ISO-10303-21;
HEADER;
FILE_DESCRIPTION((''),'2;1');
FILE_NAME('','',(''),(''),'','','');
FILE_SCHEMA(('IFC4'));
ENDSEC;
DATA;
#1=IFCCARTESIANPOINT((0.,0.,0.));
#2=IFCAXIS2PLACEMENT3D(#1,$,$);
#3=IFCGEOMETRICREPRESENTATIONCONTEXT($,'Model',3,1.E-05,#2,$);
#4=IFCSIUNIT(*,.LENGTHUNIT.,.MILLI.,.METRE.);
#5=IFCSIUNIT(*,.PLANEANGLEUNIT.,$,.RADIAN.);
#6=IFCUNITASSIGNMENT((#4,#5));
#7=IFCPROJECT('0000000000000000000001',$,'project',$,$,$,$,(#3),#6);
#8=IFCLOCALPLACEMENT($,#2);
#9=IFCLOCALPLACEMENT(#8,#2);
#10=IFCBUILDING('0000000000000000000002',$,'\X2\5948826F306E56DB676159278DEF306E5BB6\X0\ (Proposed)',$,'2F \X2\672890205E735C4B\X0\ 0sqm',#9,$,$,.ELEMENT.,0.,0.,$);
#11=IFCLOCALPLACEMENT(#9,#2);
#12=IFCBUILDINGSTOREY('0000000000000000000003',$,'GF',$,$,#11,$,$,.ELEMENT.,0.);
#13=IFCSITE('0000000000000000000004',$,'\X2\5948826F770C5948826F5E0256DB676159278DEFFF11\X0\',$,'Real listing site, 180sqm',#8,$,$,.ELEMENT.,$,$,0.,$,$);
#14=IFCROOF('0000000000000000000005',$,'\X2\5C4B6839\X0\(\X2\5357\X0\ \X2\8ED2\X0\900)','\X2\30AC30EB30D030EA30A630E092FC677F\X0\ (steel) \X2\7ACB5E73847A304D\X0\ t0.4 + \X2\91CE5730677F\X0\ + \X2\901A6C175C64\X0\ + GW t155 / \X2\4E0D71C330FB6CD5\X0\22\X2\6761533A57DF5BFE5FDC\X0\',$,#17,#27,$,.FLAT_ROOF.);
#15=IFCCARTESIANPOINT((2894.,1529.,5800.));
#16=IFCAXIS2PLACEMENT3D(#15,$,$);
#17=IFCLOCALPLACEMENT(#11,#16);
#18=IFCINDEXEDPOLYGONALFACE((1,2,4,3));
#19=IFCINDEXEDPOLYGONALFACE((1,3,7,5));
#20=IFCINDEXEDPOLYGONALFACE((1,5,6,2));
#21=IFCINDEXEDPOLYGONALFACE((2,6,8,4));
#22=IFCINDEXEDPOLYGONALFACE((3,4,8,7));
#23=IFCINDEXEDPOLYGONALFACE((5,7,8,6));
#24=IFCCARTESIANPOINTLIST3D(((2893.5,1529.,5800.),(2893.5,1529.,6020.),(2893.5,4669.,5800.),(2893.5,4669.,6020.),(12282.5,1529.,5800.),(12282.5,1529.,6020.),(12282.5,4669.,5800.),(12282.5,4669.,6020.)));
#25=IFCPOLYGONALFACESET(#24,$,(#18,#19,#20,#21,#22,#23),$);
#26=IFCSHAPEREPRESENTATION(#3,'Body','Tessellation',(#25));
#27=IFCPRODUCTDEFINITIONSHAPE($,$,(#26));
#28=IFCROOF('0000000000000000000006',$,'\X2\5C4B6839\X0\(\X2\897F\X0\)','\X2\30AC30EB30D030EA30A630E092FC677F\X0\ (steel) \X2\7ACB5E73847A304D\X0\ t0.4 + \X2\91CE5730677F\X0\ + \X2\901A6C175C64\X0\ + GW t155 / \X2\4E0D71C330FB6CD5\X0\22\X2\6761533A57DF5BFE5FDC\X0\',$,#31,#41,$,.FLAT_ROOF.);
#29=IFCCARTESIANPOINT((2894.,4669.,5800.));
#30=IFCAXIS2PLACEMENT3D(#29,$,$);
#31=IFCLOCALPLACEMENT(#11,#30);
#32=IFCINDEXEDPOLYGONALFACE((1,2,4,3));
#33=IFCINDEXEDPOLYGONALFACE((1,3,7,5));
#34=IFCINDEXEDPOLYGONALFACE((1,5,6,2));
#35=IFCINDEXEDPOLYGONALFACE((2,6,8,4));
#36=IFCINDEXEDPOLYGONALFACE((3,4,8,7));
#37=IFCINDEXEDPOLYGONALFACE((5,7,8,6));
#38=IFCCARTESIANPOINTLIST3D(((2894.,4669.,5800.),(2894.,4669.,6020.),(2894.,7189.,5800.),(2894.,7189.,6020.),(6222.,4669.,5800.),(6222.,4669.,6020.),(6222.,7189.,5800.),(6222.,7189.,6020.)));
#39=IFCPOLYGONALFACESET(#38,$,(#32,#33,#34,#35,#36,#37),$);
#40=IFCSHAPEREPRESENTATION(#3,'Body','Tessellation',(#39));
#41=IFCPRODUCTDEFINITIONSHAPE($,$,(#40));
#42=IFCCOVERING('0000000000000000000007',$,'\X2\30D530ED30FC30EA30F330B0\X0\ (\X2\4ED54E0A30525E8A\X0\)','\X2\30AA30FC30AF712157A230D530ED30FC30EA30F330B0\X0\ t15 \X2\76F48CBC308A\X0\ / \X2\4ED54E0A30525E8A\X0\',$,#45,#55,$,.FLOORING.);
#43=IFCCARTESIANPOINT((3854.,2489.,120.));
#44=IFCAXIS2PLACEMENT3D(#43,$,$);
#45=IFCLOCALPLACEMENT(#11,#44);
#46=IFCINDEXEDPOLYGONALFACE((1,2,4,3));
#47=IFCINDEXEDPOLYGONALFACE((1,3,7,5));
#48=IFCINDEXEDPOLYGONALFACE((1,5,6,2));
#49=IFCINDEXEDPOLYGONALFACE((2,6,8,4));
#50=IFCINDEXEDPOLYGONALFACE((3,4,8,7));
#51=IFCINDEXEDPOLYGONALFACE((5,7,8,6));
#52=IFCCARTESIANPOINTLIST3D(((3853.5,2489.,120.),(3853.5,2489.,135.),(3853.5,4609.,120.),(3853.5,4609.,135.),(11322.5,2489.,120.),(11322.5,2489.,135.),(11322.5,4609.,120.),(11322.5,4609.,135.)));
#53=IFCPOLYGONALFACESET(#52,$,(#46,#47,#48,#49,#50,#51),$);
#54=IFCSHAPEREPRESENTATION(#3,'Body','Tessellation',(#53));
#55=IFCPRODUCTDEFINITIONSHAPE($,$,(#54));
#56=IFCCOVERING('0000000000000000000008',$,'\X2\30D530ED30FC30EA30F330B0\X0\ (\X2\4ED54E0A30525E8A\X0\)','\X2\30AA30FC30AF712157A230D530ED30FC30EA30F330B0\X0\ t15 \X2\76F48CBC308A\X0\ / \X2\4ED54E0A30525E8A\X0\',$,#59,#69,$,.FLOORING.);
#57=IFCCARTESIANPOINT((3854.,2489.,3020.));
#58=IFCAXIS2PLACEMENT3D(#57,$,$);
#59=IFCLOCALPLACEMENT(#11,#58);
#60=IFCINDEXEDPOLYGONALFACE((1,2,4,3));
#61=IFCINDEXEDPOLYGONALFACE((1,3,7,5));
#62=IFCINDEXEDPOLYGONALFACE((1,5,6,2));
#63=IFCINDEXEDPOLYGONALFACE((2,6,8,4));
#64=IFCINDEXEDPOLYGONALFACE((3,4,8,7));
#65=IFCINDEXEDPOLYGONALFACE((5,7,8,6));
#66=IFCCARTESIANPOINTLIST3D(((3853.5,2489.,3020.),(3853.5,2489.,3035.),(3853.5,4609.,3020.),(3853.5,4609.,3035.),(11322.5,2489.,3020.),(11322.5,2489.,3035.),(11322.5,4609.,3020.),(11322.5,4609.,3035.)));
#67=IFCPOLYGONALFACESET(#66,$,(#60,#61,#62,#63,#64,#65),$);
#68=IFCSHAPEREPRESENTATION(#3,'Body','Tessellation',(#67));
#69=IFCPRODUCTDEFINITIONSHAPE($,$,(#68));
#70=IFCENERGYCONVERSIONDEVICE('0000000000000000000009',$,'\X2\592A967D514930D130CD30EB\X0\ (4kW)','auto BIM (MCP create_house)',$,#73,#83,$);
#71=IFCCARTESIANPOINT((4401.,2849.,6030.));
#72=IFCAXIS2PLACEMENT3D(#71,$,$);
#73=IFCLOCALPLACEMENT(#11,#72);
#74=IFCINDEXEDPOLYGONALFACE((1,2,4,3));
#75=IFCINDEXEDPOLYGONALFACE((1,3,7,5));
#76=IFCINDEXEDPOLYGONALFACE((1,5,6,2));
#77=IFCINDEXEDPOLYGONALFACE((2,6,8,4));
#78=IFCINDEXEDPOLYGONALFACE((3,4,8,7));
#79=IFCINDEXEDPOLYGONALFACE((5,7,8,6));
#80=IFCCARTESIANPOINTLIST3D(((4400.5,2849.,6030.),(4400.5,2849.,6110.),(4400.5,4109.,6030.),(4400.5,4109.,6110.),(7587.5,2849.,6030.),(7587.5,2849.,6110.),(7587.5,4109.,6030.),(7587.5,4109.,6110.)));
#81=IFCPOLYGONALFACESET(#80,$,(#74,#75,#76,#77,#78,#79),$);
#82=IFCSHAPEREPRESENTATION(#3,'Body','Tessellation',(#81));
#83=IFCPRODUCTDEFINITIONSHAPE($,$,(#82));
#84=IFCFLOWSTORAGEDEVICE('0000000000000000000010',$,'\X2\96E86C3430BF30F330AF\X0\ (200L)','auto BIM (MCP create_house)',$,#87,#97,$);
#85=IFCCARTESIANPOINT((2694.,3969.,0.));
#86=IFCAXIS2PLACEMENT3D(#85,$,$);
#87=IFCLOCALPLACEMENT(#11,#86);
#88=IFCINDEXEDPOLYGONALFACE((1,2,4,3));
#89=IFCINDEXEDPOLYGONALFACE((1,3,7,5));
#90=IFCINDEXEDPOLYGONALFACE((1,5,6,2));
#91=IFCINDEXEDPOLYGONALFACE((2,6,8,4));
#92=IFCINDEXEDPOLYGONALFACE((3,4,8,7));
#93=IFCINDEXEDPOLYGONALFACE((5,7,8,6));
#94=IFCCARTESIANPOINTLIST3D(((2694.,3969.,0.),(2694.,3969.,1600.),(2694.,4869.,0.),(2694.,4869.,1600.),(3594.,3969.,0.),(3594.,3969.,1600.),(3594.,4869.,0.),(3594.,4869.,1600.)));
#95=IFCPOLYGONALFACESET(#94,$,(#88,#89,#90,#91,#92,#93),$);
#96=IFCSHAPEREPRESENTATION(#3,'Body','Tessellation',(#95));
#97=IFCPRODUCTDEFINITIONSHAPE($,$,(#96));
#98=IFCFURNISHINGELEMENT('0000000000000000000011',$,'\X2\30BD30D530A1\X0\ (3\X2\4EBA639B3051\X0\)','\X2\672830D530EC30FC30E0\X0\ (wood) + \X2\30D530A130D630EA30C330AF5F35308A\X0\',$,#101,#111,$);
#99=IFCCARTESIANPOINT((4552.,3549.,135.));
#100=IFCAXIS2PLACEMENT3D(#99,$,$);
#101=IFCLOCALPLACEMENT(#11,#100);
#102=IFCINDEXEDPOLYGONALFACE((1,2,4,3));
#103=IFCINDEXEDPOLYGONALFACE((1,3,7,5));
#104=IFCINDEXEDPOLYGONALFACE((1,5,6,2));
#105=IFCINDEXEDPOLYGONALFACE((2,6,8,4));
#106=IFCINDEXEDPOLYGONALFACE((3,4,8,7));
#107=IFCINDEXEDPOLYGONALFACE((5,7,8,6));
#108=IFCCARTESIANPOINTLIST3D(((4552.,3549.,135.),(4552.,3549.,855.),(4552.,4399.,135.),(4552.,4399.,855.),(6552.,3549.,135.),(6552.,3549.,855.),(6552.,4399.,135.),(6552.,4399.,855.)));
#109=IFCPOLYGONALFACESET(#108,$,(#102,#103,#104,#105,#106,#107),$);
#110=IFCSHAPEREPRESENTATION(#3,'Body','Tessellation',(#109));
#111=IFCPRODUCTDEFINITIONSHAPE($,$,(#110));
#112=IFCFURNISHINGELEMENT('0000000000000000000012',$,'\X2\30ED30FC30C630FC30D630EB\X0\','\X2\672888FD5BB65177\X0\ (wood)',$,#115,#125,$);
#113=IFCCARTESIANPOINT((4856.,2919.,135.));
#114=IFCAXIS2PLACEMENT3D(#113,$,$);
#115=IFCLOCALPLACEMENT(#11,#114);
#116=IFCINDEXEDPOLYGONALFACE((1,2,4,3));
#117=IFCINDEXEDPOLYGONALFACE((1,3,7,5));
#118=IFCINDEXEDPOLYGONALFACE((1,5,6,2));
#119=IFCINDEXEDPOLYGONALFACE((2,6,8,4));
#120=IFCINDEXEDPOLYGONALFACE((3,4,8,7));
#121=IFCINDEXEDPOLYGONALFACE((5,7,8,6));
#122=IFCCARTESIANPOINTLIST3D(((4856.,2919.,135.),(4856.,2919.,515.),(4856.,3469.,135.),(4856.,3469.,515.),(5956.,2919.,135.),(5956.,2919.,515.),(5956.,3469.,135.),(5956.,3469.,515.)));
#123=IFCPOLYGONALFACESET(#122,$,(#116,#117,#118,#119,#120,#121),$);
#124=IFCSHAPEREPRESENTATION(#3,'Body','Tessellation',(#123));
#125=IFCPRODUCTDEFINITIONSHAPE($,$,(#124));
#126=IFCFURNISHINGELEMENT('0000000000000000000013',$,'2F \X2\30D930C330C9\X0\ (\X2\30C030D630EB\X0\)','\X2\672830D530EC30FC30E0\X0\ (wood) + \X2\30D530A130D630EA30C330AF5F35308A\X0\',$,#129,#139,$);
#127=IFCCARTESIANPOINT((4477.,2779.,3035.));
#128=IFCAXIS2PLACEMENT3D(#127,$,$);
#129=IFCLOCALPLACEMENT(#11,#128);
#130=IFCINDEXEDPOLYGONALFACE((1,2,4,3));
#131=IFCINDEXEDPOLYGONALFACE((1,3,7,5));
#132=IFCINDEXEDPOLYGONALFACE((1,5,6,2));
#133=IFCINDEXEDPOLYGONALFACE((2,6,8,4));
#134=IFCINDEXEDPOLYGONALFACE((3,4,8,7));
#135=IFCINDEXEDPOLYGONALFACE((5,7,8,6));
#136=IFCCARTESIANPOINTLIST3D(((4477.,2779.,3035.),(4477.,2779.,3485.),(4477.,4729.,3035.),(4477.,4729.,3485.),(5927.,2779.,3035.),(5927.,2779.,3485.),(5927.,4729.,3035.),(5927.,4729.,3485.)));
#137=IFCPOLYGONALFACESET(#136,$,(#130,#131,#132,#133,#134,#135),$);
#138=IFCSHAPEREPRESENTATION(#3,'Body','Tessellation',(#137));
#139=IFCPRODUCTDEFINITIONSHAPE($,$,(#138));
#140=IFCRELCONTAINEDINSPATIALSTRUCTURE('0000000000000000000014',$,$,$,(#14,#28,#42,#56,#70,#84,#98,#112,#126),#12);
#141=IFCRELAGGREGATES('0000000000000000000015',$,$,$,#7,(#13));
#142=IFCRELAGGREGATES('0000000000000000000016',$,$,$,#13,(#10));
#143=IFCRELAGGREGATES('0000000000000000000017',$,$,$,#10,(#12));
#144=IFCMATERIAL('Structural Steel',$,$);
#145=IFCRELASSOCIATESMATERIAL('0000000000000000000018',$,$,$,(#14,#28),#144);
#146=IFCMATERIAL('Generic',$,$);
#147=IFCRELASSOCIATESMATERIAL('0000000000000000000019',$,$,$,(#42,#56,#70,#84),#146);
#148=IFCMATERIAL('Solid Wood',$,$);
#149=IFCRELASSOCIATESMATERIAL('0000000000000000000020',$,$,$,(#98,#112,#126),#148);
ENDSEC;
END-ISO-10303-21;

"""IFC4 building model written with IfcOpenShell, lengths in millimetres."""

from ifc_helpers import new_model, si_unit, frame, frame_2d, origin, place, context, project, spatial, rectangle, extrude, material, element, save


model = new_model("IFC4")

# Units and contexts
model_context = context("Model", 3, precision=1e-05, world=origin())
ifc_project = project(units=[si_unit("LENGTHUNIT", "METRE", prefix="MILLI"), si_unit("PLANEANGLEUNIT", "RADIAN")], contexts=[model_context])

# Site, building, storey
site_placement = place(None, origin())
site = spatial("IfcSite", under=ifc_project, at=site_placement, Name="奈良県奈良市四条大路１", ObjectType="Real listing site, 180sqm", CompositionType="ELEMENT", RefElevation=0.0)
building_placement = place(site_placement, origin())
building = spatial("IfcBuilding", under=site, at=building_placement, Name="奈良の四条大路の家 (Proposed)", ObjectType="2F 木造平屋 0sqm", CompositionType="ELEMENT", ElevationOfRefHeight=0.0, ElevationOfTerrain=0.0)
storey_placement = place(building_placement, origin())
storey = spatial("IfcBuildingStorey", under=building, at=storey_placement, Name="GF", CompositionType="ELEMENT", Elevation=0.0)

# Shared definitions
ifc_material_1 = material(Name="Solid Wood")

# Roofs
ifc_material_2 = material(Name="Structural Steel")
roof_1_placement = place(storey_placement, frame((2894.0, 1529.0, 5800.0)))
element("IfcRoof", 1, at=roof_1_placement, inside=storey, material=ifc_material_2, Name="屋根(南 軒900)", Description="ガルバリウム鋼板 (steel) 立平葺き t0.4 + 野地板 + 通気層 + GW t155 / 不燃・法22条区域対応", PredefinedType="FLAT_ROOF", context=model_context, shape_type="SweptSolid", body=[
    extrude(rectangle(XDim=9389.0, YDim=3140.0, at=frame_2d((4694.0, 1570.0))), frame((2894.0, 1529.0, 5800.0)), (0.0, 0.0, 1.0), 220.0),
])
roof_2_placement = place(storey_placement, frame((2894.0, 4669.0, 5800.0)))
element("IfcRoof", 2, at=roof_2_placement, inside=storey, material=ifc_material_2, Name="屋根(西)", Description="ガルバリウム鋼板 (steel) 立平葺き t0.4 + 野地板 + 通気層 + GW t155 / 不燃・法22条区域対応", PredefinedType="FLAT_ROOF", context=model_context, shape_type="SweptSolid", body=[
    extrude(rectangle(XDim=3328.0, YDim=2520.0, at=frame_2d((1664.0, 1260.0))), frame((2894.0, 4669.0, 5800.0)), (0.0, 0.0, 1.0), 220.0),
])

# Coverings
ifc_material_3 = material(Name="Generic")
covering_1_placement = place(storey_placement, frame((3854.0, 2489.0, 120.0)))
element("IfcCovering", 3, at=covering_1_placement, inside=storey, material=ifc_material_3, Name="フローリング (仕上げ床)", Description="オーク無垢フローリング t15 直貼り / 仕上げ床", PredefinedType="FLOORING", context=model_context, shape_type="SweptSolid", body=[
    extrude(rectangle(XDim=7469.0, YDim=2120.0, at=frame_2d((3734.0, 1060.0))), frame((3854.0, 2489.0, 120.0)), (0.0, 0.0, 1.0), 15.0),
])
covering_2_placement = place(storey_placement, frame((3854.0, 2489.0, 3020.0)))
element("IfcCovering", 4, at=covering_2_placement, inside=storey, material=ifc_material_3, Name="フローリング (仕上げ床)", Description="オーク無垢フローリング t15 直貼り / 仕上げ床", PredefinedType="FLOORING", context=model_context, shape_type="SweptSolid", body=[
    extrude(rectangle(XDim=7469.0, YDim=2120.0, at=frame_2d((3734.0, 1060.0))), frame((3854.0, 2489.0, 3020.0)), (0.0, 0.0, 1.0), 15.0),
])

# Energy conversion device
energy_conversion_device_placement = place(storey_placement, frame((4401.0, 2849.0, 6030.0)))
element("IfcEnergyConversionDevice", 5, at=energy_conversion_device_placement, inside=storey, material=ifc_material_3, Name="太陽光パネル (4kW)", Description="auto BIM (MCP create_house)", context=model_context, shape_type="SweptSolid", body=[
    extrude(rectangle(XDim=3187.0, YDim=1260.0, at=frame_2d((1593.0, 630.0))), frame((4401.0, 2849.0, 6030.0)), (0.0, 0.0, 1.0), 80.0),
])

# Flow storage device
flow_storage_device_placement = place(storey_placement, frame((2694.0, 3969.0, 0.0)))
element("IfcFlowStorageDevice", 6, at=flow_storage_device_placement, inside=storey, material=ifc_material_3, Name="雨水タンク (200L)", Description="auto BIM (MCP create_house)", context=model_context, shape_type="SweptSolid", body=[
    extrude(rectangle(XDim=900.0, YDim=900.0, at=frame_2d((450.0, 450.0))), frame((2694.0, 3969.0, 0.0)), (0.0, 0.0, 1.0), 1600.0),
])

# Furnishing elements
furnishing_1_placement = place(storey_placement, frame((4552.0, 3549.0, 135.0)))
element("IfcFurnishingElement", 7, at=furnishing_1_placement, inside=storey, material=ifc_material_1, Name="ソファ (3人掛け)", Description="木フレーム (wood) + ファブリック張り", context=model_context, shape_type="SweptSolid", body=[
    extrude(rectangle(XDim=2000.0, YDim=850.0, at=frame_2d((1000.0, 425.0))), frame((4552.0, 3549.0, 135.0)), (0.0, 0.0, 1.0), 720.0),
])
furnishing_2_placement = place(storey_placement, frame((4856.0, 2919.0, 135.0)))
element("IfcFurnishingElement", 8, at=furnishing_2_placement, inside=storey, material=ifc_material_1, Name="ローテーブル", Description="木製家具 (wood)", context=model_context, shape_type="SweptSolid", body=[
    extrude(rectangle(XDim=1100.0, YDim=550.0, at=frame_2d((550.0, 275.0))), frame((4856.0, 2919.0, 135.0)), (0.0, 0.0, 1.0), 380.0),
])
furnishing_3_placement = place(storey_placement, frame((4477.0, 2779.0, 3035.0)))
element("IfcFurnishingElement", 9, at=furnishing_3_placement, inside=storey, material=ifc_material_1, Name="2F ベッド (ダブル)", Description="木フレーム (wood) + ファブリック張り", context=model_context, shape_type="SweptSolid", body=[
    extrude(rectangle(XDim=1450.0, YDim=1950.0, at=frame_2d((725.0, 975.0))), frame((4477.0, 2779.0, 3035.0)), (0.0, 0.0, 1.0), 450.0),
])

save(model, "model.ifc")
